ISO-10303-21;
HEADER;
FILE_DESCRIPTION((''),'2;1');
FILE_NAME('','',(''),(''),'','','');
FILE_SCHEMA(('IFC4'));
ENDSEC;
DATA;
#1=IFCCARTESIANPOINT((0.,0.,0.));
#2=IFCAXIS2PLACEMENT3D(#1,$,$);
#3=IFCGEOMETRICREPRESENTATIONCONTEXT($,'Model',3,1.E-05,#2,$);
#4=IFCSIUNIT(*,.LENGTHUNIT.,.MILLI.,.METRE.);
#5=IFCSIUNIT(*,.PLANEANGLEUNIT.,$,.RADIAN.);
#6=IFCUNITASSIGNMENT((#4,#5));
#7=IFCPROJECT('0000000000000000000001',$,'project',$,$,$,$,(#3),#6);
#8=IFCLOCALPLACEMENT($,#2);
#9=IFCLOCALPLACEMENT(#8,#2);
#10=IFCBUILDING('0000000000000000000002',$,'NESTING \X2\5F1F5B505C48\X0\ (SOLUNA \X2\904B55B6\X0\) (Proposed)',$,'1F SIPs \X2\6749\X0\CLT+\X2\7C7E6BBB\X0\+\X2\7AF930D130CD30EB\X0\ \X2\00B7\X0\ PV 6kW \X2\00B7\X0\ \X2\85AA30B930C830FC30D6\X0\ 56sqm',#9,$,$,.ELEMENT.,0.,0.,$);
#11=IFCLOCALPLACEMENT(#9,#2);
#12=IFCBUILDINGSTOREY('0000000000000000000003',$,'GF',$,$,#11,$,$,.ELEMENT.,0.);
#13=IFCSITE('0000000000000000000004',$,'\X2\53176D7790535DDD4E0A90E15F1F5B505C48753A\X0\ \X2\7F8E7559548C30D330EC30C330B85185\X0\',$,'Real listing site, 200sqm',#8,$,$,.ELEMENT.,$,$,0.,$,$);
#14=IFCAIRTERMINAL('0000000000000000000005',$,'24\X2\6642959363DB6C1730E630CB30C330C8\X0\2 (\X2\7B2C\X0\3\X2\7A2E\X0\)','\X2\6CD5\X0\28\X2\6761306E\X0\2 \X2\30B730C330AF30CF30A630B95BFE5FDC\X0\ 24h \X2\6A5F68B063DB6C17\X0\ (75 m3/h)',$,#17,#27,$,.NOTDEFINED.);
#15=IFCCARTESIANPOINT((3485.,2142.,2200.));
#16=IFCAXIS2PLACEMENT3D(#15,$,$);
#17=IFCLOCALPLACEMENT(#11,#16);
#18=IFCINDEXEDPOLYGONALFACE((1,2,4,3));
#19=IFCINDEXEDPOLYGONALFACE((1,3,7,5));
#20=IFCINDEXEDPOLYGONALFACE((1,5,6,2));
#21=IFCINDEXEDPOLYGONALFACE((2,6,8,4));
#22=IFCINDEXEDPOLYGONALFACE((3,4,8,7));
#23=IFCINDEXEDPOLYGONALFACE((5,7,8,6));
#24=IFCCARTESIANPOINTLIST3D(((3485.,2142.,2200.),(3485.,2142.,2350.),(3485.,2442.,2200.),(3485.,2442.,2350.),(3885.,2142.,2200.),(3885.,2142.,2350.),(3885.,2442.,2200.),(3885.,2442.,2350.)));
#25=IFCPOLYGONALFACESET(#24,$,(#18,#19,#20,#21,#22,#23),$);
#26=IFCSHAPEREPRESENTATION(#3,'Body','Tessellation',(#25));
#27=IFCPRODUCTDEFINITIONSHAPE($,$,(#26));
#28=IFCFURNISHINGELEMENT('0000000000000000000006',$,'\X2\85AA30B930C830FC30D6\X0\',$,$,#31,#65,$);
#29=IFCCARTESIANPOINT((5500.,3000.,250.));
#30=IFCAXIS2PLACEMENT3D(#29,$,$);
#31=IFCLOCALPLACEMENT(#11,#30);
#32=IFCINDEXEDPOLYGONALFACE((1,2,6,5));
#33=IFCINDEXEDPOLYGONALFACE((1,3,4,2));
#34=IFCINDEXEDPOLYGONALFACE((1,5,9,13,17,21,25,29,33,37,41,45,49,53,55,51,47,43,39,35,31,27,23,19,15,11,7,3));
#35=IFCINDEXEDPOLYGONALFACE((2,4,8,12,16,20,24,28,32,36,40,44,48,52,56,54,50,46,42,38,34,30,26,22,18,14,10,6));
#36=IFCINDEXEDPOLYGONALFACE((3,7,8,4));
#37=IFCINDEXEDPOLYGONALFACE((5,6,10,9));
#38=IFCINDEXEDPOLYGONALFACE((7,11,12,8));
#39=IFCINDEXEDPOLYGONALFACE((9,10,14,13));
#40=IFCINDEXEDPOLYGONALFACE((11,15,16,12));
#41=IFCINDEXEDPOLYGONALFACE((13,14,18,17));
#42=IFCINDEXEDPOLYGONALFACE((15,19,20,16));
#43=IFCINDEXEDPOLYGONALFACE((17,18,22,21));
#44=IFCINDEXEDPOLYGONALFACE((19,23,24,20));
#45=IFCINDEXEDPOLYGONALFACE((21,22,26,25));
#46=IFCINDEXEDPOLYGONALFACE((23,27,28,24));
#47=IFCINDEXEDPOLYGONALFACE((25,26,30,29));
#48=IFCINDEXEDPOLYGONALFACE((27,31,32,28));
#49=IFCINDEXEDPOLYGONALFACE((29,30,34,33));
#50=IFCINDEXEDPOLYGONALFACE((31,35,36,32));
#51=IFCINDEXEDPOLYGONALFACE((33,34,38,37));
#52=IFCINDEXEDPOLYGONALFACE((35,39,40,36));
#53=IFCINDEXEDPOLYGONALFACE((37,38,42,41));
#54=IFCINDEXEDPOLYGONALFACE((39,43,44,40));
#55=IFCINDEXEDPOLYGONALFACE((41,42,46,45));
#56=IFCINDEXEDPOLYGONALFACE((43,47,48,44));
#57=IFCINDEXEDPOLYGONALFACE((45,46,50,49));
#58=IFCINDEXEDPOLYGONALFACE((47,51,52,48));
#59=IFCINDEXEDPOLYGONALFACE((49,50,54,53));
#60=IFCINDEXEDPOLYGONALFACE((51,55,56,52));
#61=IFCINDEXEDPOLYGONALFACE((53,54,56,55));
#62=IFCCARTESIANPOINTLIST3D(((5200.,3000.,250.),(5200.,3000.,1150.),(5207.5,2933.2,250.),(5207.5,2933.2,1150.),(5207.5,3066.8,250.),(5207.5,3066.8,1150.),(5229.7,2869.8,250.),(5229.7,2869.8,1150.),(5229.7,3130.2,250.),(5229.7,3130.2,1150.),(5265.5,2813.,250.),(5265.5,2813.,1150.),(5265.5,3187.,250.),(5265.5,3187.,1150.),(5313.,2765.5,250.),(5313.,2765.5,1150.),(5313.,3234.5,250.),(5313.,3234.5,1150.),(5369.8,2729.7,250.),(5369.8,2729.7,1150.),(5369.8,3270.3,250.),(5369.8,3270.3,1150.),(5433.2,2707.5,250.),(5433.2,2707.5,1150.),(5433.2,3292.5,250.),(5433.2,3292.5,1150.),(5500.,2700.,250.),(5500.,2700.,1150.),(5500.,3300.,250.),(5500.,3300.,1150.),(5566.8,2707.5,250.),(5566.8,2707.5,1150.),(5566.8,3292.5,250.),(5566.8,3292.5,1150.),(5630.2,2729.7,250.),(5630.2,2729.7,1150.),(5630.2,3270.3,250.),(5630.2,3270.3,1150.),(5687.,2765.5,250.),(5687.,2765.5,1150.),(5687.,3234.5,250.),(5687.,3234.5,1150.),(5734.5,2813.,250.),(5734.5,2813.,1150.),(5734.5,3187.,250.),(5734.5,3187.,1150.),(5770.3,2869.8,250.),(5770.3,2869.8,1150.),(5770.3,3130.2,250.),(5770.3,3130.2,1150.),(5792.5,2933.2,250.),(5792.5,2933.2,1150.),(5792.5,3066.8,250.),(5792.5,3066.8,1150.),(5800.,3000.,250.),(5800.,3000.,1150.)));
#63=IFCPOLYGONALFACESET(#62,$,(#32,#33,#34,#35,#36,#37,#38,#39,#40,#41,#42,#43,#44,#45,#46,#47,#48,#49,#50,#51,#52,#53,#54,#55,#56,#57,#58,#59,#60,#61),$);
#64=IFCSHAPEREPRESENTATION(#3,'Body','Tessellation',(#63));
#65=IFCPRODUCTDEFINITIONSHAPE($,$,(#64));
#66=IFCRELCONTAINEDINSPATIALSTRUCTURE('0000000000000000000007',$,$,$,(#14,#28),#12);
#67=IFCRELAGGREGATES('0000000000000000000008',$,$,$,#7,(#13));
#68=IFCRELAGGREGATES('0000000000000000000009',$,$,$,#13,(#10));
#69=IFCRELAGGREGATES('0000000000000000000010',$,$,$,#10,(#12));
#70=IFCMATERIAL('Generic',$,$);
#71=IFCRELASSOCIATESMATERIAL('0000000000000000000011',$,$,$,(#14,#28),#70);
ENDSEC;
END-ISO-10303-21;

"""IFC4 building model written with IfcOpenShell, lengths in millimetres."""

from ifc_helpers import new_model, si_unit, frame, frame_2d, origin, origin_2d, place, context, project, spatial, rectangle, circle, extrude, material, element, save


model = new_model("IFC4")

# Units and contexts
model_context = context("Model", 3, precision=1e-05, world=origin())
ifc_project = project(units=[si_unit("LENGTHUNIT", "METRE", prefix="MILLI"), si_unit("PLANEANGLEUNIT", "RADIAN")], contexts=[model_context])

# Site, building, storey
site_placement = place(None, origin())
site = spatial("IfcSite", under=ifc_project, at=site_placement, Name="北海道川上郡弟子屈町 美留和ビレッジ内", ObjectType="Real listing site, 200sqm", CompositionType="ELEMENT", RefElevation=0.0)
building_placement = place(site_placement, origin())
building = spatial("IfcBuilding", under=site, at=building_placement, Name="NESTING 弟子屈 (SOLUNA 運営) (Proposed)", ObjectType="1F SIPs 杉CLT+籾殻+竹パネル · PV 6kW · 薪ストーブ 56sqm", CompositionType="ELEMENT", ElevationOfRefHeight=0.0, ElevationOfTerrain=0.0)
storey_placement = place(building_placement, origin())
storey = spatial("IfcBuildingStorey", under=building, at=storey_placement, Name="GF", CompositionType="ELEMENT", Elevation=0.0)

# Shared definitions
ifc_material_1 = material(Name="Generic")

# Air terminal
air_terminal_1_placement = place(storey_placement, frame((3485.0, 2142.0, 2200.0)))
element("IfcAirTerminal", 1, at=air_terminal_1_placement, inside=storey, material=ifc_material_1, Name="24時間換気ユニット2 (第3種)", Description="法28条の2 シックハウス対応 24h 機械換気 (75 m3/h)", PredefinedType="NOTDEFINED", context=model_context, shape_type="SweptSolid", body=[
    extrude(rectangle(XDim=400.0, YDim=300.0, at=frame_2d((200.0, 150.0))), frame((3485.0, 2142.0, 2200.0)), (0.0, 0.0, 1.0), 150.0),
])

# Furnishing element
furnishing_1_placement = place(storey_placement, frame((5500.0, 3000.0, 250.0)))
element("IfcFurnishingElement", 2, at=furnishing_1_placement, inside=storey, material=ifc_material_1, Name="薪ストーブ", context=model_context, shape_type="SweptSolid", body=[
    extrude(circle(Radius=300.0, at=origin_2d()), frame((5500.0, 3000.0, 250.0)), (0.0, 0.0, 1.0), 900.0),
])

save(model, "model.ifc")
